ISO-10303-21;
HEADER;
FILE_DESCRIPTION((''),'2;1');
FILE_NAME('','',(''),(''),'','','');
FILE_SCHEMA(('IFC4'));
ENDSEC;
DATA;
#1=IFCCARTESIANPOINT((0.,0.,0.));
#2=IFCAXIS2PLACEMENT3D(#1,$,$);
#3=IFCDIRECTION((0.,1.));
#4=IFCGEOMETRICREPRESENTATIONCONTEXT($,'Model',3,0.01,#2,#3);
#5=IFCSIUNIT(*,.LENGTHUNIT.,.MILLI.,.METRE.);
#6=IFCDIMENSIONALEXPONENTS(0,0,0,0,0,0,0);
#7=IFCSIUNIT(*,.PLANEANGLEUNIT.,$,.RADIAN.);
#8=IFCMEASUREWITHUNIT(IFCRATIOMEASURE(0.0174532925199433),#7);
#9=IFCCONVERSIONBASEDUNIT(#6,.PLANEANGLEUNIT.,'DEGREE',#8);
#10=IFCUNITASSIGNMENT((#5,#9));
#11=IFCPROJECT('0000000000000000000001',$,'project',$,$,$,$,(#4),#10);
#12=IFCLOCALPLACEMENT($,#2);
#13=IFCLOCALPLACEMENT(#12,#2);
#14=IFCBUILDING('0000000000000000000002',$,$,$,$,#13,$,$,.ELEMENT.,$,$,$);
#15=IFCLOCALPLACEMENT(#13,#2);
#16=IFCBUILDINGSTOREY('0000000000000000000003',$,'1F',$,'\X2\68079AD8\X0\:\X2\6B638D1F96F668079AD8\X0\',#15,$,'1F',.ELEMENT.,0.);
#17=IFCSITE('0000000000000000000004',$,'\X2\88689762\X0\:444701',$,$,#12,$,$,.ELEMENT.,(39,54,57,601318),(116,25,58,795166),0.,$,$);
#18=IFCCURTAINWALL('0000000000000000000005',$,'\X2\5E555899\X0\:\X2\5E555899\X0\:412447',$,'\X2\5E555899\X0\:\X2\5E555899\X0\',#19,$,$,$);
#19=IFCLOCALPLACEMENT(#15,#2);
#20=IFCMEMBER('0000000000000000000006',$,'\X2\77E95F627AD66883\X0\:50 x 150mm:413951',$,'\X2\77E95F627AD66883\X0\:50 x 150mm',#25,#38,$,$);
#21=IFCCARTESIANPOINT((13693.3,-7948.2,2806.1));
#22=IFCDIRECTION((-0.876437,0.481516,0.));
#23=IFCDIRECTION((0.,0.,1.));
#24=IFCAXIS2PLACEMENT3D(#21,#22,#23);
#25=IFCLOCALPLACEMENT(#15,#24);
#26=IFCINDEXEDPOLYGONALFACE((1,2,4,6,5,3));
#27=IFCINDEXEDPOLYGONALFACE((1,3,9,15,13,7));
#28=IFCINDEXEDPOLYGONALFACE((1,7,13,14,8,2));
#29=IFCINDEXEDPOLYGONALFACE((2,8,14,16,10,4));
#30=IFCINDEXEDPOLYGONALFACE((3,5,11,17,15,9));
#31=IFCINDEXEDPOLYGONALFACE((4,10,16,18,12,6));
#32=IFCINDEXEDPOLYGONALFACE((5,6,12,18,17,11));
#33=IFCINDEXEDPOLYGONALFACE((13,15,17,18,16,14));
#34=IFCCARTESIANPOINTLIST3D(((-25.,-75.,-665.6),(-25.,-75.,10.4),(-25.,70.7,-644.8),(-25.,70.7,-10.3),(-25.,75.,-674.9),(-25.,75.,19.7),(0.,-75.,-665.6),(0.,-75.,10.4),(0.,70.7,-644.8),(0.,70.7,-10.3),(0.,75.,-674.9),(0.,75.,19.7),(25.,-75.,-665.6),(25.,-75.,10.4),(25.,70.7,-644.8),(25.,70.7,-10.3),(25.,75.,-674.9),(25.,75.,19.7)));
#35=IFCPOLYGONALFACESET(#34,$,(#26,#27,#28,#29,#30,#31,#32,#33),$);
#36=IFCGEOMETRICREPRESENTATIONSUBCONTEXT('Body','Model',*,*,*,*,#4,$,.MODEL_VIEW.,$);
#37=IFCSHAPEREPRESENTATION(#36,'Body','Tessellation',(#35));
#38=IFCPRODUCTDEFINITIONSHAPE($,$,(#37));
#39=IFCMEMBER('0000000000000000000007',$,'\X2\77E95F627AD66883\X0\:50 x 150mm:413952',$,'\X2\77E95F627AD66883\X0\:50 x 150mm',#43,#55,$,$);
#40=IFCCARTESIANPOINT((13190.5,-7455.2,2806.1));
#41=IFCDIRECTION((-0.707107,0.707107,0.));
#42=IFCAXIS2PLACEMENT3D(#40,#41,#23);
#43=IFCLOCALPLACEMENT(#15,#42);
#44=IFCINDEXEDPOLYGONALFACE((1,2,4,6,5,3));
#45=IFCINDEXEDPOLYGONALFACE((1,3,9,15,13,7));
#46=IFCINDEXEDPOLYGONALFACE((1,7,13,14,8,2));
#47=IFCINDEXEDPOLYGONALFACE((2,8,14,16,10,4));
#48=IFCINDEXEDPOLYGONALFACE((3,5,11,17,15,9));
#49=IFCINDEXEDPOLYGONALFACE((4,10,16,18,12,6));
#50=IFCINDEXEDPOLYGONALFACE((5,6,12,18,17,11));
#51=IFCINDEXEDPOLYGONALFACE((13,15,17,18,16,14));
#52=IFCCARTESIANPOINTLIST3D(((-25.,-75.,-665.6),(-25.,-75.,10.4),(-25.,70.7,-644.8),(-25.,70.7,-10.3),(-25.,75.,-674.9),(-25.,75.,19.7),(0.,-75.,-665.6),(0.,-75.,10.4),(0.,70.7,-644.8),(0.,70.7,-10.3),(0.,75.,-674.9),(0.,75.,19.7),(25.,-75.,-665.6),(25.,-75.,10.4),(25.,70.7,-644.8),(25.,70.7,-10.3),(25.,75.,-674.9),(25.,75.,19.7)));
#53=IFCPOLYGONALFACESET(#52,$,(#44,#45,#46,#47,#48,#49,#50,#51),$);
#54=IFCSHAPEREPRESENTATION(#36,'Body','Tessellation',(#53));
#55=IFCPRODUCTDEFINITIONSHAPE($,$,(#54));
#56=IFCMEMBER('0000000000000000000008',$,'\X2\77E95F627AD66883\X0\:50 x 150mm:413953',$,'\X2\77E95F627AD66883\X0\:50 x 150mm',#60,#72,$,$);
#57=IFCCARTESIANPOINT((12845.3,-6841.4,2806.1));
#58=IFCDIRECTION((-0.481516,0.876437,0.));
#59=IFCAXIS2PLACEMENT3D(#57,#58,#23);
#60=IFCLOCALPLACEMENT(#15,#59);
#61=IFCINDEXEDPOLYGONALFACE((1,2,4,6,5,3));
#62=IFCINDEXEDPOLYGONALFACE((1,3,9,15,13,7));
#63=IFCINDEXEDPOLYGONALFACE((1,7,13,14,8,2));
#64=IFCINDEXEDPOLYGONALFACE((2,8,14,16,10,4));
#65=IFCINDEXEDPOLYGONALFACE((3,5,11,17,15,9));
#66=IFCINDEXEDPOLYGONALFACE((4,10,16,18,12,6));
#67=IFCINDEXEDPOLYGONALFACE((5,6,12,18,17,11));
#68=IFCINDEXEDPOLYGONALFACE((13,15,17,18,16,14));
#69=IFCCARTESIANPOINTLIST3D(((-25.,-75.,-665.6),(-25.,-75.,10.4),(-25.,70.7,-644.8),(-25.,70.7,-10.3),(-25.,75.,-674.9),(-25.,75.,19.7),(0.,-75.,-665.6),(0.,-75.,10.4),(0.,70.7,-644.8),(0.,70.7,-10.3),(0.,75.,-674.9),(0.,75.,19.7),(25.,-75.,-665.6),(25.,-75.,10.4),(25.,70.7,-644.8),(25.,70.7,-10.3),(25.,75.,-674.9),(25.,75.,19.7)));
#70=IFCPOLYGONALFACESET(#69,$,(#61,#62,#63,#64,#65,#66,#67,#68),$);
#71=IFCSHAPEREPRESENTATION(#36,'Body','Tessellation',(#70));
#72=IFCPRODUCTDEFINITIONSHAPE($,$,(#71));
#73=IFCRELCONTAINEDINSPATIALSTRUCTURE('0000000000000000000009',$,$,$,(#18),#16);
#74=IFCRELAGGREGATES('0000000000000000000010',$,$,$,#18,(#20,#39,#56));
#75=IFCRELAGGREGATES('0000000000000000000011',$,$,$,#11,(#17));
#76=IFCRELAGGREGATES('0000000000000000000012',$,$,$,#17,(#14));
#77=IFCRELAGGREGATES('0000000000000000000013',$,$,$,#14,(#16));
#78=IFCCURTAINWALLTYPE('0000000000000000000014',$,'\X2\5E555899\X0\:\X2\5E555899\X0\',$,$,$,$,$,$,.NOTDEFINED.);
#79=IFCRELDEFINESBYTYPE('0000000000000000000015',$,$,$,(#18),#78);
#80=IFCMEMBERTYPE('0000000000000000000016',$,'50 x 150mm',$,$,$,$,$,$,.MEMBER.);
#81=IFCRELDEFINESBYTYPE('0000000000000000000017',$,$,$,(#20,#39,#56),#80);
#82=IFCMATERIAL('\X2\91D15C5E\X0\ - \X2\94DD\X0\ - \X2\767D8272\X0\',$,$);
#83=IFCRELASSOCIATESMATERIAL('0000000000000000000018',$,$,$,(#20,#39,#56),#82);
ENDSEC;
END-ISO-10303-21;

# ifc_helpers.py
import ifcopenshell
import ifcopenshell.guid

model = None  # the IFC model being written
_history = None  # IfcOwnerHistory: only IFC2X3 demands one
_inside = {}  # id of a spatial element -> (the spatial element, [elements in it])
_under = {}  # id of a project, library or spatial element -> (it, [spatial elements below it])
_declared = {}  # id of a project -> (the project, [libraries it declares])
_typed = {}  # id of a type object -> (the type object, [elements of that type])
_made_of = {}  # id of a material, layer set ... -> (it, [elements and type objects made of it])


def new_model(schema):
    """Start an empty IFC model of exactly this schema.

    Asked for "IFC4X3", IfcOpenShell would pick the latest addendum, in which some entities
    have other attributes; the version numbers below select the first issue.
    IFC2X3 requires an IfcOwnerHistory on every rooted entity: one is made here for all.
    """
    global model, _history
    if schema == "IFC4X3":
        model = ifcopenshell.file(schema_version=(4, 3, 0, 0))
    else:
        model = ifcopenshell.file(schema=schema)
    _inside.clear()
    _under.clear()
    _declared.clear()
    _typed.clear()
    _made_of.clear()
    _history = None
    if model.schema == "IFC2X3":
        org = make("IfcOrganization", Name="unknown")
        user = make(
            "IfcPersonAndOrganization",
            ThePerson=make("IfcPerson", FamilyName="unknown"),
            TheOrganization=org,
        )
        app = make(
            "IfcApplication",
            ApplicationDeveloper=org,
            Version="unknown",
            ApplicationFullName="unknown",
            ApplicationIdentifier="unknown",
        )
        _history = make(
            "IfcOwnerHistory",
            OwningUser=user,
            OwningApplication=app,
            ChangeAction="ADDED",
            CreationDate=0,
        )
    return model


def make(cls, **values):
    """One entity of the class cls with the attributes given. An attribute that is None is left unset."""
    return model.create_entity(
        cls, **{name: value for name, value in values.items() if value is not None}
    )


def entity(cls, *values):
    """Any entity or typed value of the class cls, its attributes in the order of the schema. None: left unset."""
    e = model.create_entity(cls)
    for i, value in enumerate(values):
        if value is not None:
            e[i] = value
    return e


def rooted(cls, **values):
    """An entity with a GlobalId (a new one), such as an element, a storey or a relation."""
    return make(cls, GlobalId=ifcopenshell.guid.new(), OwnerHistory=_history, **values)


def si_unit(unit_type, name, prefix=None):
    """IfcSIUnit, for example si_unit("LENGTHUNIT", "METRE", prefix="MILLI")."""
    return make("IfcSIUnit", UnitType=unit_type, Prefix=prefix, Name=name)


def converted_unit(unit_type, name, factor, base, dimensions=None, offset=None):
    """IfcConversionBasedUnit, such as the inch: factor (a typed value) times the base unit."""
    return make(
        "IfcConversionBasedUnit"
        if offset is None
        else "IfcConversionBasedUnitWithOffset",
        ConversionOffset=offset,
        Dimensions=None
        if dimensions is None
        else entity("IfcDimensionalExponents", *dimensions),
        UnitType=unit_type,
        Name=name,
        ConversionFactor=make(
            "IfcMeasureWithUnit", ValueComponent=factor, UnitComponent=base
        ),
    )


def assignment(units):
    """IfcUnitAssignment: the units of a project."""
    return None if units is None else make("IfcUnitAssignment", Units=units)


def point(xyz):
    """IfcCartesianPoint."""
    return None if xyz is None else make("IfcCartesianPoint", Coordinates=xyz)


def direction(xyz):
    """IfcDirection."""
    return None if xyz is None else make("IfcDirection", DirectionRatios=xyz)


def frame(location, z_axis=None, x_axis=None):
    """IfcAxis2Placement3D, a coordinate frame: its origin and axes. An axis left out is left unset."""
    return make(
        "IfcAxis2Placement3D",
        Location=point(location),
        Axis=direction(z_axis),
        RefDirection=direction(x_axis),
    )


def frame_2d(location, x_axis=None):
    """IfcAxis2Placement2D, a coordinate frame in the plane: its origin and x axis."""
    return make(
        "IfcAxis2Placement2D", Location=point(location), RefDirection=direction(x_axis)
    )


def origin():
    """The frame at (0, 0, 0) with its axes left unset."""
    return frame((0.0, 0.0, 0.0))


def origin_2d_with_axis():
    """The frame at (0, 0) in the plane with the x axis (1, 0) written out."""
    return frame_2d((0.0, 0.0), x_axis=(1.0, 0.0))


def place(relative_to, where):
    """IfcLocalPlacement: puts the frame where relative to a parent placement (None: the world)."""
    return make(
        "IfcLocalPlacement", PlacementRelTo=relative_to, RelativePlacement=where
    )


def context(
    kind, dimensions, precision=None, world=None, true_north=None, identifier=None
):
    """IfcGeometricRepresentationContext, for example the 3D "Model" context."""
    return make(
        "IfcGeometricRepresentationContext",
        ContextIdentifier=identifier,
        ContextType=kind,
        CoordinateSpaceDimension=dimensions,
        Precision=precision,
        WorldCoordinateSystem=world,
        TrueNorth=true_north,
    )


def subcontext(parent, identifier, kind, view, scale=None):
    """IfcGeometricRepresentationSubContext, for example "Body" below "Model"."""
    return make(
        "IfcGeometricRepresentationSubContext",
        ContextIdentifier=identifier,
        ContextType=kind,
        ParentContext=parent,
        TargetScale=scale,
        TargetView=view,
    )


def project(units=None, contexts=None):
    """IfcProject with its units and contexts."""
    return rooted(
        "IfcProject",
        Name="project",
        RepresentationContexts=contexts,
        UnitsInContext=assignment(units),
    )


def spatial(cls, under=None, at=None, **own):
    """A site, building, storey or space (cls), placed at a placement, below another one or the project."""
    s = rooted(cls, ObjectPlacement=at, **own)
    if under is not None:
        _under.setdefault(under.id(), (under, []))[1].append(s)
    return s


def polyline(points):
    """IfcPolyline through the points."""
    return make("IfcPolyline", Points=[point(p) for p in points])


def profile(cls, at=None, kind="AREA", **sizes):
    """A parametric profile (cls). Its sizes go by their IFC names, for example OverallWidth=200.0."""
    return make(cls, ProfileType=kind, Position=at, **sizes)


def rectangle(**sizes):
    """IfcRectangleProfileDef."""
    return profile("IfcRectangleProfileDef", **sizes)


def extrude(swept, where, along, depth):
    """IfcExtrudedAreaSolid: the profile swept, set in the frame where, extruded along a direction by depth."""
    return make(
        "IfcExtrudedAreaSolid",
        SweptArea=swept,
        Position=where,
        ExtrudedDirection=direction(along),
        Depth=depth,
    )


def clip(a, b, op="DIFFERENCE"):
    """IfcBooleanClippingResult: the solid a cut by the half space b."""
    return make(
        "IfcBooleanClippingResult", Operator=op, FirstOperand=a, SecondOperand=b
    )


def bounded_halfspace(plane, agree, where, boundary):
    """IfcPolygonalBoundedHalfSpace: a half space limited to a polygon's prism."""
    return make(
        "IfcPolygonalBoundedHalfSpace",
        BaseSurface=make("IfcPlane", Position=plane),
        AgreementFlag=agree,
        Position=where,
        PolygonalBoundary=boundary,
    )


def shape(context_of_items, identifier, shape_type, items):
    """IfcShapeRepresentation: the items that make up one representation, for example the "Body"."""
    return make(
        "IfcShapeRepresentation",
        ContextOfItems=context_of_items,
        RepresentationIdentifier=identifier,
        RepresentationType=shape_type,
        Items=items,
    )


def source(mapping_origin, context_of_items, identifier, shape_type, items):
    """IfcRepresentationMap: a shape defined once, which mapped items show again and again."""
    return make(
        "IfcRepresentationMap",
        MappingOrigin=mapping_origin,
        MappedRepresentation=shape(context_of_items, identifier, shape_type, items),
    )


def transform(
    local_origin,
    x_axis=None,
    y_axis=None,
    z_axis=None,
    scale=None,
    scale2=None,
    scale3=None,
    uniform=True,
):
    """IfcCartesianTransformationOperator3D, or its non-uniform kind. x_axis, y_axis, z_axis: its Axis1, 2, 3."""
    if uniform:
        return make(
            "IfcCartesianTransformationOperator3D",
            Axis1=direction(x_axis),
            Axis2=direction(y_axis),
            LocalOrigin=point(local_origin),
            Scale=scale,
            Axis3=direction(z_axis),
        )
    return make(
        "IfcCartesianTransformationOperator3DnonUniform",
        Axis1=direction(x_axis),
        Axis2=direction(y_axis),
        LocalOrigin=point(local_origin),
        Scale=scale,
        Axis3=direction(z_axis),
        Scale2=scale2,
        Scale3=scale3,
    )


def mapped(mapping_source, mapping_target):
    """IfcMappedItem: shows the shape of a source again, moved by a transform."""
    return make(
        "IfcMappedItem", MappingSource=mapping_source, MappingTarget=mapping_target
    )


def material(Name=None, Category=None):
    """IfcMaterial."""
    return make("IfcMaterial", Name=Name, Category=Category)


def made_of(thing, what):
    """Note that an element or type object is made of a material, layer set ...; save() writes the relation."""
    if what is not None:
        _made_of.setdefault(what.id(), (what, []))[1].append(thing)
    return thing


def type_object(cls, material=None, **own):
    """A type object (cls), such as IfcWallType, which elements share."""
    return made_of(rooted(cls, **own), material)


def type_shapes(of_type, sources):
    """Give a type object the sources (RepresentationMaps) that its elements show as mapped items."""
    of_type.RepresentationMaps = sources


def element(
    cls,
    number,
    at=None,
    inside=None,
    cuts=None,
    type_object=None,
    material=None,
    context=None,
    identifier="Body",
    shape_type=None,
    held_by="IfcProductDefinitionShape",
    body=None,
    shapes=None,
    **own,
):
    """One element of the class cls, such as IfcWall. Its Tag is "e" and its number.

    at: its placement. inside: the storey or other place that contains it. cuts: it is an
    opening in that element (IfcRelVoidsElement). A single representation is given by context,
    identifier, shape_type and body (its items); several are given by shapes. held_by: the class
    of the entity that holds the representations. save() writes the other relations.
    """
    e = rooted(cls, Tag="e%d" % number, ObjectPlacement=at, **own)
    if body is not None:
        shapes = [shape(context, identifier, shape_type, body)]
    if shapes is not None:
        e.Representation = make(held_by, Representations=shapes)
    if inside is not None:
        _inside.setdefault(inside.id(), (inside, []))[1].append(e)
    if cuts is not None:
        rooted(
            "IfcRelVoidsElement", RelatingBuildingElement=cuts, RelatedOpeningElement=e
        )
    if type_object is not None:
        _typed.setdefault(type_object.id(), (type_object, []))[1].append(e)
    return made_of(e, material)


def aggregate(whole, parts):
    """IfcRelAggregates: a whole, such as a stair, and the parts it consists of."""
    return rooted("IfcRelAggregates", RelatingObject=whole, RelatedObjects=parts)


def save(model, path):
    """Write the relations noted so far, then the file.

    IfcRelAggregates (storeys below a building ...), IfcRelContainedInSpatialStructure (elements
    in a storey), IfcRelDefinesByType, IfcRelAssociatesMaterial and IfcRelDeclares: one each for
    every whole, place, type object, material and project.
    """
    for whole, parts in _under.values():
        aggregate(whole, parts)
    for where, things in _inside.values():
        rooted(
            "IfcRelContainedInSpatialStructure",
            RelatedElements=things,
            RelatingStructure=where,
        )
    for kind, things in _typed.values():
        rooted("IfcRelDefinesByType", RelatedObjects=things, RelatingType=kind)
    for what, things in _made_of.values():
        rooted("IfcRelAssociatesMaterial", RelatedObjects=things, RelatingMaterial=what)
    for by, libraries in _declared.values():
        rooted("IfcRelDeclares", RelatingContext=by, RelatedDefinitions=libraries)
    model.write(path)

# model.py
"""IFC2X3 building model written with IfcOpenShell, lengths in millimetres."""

from ifc_helpers import new_model, entity, si_unit, converted_unit, direction, frame, origin, origin_2d_with_axis, place, context, subcontext, project, spatial, polyline, rectangle, extrude, clip, bounded_halfspace, source, transform, mapped, material, type_object, type_shapes, element, aggregate, save


model = new_model("IFC2X3")

# Units and contexts
model_context = context("Model", 3, precision=0.01, world=origin(), true_north=direction((0.0, 1.0)))
body_context = subcontext(model_context, "Body", "Model", "MODEL_VIEW")
ifc_project = project(units=[si_unit("LENGTHUNIT", "METRE", prefix="MILLI"), converted_unit("PLANEANGLEUNIT", "DEGREE", entity("IfcRatioMeasure", 0.0174532925199433), si_unit("PLANEANGLEUNIT", "RADIAN"), dimensions=[0, 0, 0, 0, 0, 0, 0])], contexts=[model_context])

# Site, building, storey
site_placement = place(None, origin())
site = spatial("IfcSite", under=ifc_project, at=site_placement, Name="表面:444701", CompositionType="ELEMENT", RefLatitude=(39, 54, 57, 601318), RefLongitude=(116, 25, 58, 795166), RefElevation=0.0)
building_placement = place(site_placement, origin())
building = spatial("IfcBuilding", under=site, at=building_placement, CompositionType="ELEMENT")
storey_placement = place(building_placement, origin())
storey = spatial("IfcBuildingStorey", under=building, at=storey_placement, Name="1F", ObjectType="标高:正负零标高", LongName="1F", CompositionType="ELEMENT", Elevation=0.0)

# Curtain wall, members
curtain_wall_type = type_object("IfcCurtainWallType", Name="幕墙:幕墙", PredefinedType="NOTDEFINED")
curtain_wall_placement = place(storey_placement, origin())
curtain_wall = element("IfcCurtainWall", 1, at=curtain_wall_placement, inside=storey, type_object=curtain_wall_type, Name="幕墙:幕墙:412447", ObjectType="幕墙:幕墙")
ifc_material_1 = material(Name="金属 - 铝 - 白色")
member_type_1 = type_object("IfcMemberType", Name="50 x 150mm", PredefinedType="MEMBER")
shared_shape_1 = source(origin(), body_context, "Body", "Clipping", [
    clip(clip(clip(clip(clip(clip(clip(clip(extrude(rectangle(XDim=150.0, YDim=50.0, at=origin_2d_with_axis()), frame((0.0, 0.0, -674.9), z_axis=(0.0, 0.0, 1.0), x_axis=(0.0, -1.0, 0.0)), (0.0, 0.0, 1.0), 694.5), bounded_halfspace(frame((-1390.5, -77.8, -666.0), z_axis=(0.0, 0.141035, -0.990005), x_axis=(1.0, 0.0, 0.0)), False, frame((0.0, 0.0, -674.9), z_axis=(0.0, 0.0, 1.0), x_axis=(0.0, -1.0, 0.0)), polyline([(75.0, 0.0), (75.0, -25.0), (-70.7, -25.0), (-70.7, 0.0), (75.0, 0.0)]))), bounded_halfspace(frame((0.0, -77.8, -666.0), z_axis=(0.0, 0.141035, -0.990005), x_axis=(1.0, 0.0, 0.0)), False, frame((0.0, 0.0, -674.9), z_axis=(0.0, 0.0, 1.0), x_axis=(0.0, -1.0, 0.0)), polyline([(-70.7, 25.0), (75.0, 25.0), (75.0, 0.0), (-70.7, 0.0), (-70.7, 25.0)]))), bounded_halfspace(frame((-1390.5, 70.7, -644.8), z_axis=(0.0, -0.990005, -0.141035), x_axis=(1.0, 0.0, 0.0)), False, frame((0.0, 0.0, -674.9), z_axis=(0.0, 0.0, 1.0), x_axis=(0.0, -1.0, 0.0)), polyline([(-70.7, -25.0), (-75.0, -25.0), (-75.0, 0.0), (-70.7, 0.0), (-70.7, -25.0)]))), bounded_halfspace(frame((0.0, 70.7, -644.8), z_axis=(0.0, -0.990005, -0.141035), x_axis=(1.0, 0.0, 0.0)), False, frame((0.0, 0.0, -674.9), z_axis=(0.0, 0.0, 1.0), x_axis=(0.0, -1.0, 0.0)), polyline([(-75.0, 25.0), (-70.7, 25.0), (-70.7, 0.0), (-75.0, 0.0), (-75.0, 25.0)]))), bounded_halfspace(frame((-1390.5, 77.8, 39.2), z_axis=(0.0, -0.990005, 0.141035), x_axis=(1.0, 0.0, 0.0)), False, frame((0.0, 0.0, -674.9), z_axis=(0.0, 0.0, 1.0), x_axis=(0.0, -1.0, 0.0)), polyline([(-75.0, 0.0), (-75.0, -25.0), (-70.7, -25.0), (-70.7, 0.0), (-75.0, 0.0)]))), bounded_halfspace(frame((0.0, 77.8, 39.2), z_axis=(0.0, -0.990005, 0.141035), x_axis=(1.0, 0.0, 0.0)), False, frame((0.0, 0.0, -674.9), z_axis=(0.0, 0.0, 1.0), x_axis=(0.0, -1.0, 0.0)), polyline([(-75.0, 25.0), (-75.0, 0.0), (-70.7, 0.0), (-70.7, 25.0), (-75.0, 25.0)]))), bounded_halfspace(frame((-1390.5, 70.7, -10.3), z_axis=(0.0, 0.141035, 0.990005), x_axis=(1.0, 0.0, 0.0)), False, frame((0.0, 0.0, -674.9), z_axis=(0.0, 0.0, 1.0), x_axis=(0.0, -1.0, 0.0)), polyline([(-70.7, -25.0), (75.0, -25.0), (75.0, 0.0), (-70.7, 0.0), (-70.7, -25.0)]))), bounded_halfspace(frame((0.0, 70.7, -10.3), z_axis=(0.0, 0.141035, 0.990005), x_axis=(1.0, 0.0, 0.0)), False, frame((0.0, 0.0, -674.9), z_axis=(0.0, 0.0, 1.0), x_axis=(0.0, -1.0, 0.0)), polyline([(75.0, 0.0), (75.0, 25.0), (-70.7, 25.0), (-70.7, 0.0), (75.0, 0.0)]))),
])
type_shapes(member_type_1, [shared_shape_1])
member_1_placement = place(storey_placement, frame((13693.3, -7948.2, 2806.1), z_axis=(-0.876437, 0.481516, 0.0), x_axis=(0.0, 0.0, 1.0)))
member_1 = element("IfcMember", 2, at=member_1_placement, type_object=member_type_1, material=ifc_material_1, Name="矩形竖梃:50 x 150mm:413951", ObjectType="矩形竖梃:50 x 150mm", context=body_context, shape_type="MappedRepresentation", body=[
    mapped(shared_shape_1, transform((0.0, 0.0, 0.0), scale=1.0)),
])
member_2_placement = place(storey_placement, frame((13190.5, -7455.2, 2806.1), z_axis=(-0.707107, 0.707107, 0.0), x_axis=(0.0, 0.0, 1.0)))
member_2 = element("IfcMember", 3, at=member_2_placement, type_object=member_type_1, material=ifc_material_1, Name="矩形竖梃:50 x 150mm:413952", ObjectType="矩形竖梃:50 x 150mm", context=body_context, shape_type="MappedRepresentation", body=[
    mapped(shared_shape_1, transform((0.0, 0.0, 0.0), scale=1.0)),
])
member_3_placement = place(storey_placement, frame((12845.3, -6841.4, 2806.1), z_axis=(-0.481516, 0.876437, 0.0), x_axis=(0.0, 0.0, 1.0)))
member_3 = element("IfcMember", 4, at=member_3_placement, type_object=member_type_1, material=ifc_material_1, Name="矩形竖梃:50 x 150mm:413953", ObjectType="矩形竖梃:50 x 150mm", context=body_context, shape_type="MappedRepresentation", body=[
    mapped(shared_shape_1, transform((0.0, 0.0, 0.0), scale=1.0)),
])
aggregate(curtain_wall, [member_1, member_2, member_3])

save(model, "model.ifc")
